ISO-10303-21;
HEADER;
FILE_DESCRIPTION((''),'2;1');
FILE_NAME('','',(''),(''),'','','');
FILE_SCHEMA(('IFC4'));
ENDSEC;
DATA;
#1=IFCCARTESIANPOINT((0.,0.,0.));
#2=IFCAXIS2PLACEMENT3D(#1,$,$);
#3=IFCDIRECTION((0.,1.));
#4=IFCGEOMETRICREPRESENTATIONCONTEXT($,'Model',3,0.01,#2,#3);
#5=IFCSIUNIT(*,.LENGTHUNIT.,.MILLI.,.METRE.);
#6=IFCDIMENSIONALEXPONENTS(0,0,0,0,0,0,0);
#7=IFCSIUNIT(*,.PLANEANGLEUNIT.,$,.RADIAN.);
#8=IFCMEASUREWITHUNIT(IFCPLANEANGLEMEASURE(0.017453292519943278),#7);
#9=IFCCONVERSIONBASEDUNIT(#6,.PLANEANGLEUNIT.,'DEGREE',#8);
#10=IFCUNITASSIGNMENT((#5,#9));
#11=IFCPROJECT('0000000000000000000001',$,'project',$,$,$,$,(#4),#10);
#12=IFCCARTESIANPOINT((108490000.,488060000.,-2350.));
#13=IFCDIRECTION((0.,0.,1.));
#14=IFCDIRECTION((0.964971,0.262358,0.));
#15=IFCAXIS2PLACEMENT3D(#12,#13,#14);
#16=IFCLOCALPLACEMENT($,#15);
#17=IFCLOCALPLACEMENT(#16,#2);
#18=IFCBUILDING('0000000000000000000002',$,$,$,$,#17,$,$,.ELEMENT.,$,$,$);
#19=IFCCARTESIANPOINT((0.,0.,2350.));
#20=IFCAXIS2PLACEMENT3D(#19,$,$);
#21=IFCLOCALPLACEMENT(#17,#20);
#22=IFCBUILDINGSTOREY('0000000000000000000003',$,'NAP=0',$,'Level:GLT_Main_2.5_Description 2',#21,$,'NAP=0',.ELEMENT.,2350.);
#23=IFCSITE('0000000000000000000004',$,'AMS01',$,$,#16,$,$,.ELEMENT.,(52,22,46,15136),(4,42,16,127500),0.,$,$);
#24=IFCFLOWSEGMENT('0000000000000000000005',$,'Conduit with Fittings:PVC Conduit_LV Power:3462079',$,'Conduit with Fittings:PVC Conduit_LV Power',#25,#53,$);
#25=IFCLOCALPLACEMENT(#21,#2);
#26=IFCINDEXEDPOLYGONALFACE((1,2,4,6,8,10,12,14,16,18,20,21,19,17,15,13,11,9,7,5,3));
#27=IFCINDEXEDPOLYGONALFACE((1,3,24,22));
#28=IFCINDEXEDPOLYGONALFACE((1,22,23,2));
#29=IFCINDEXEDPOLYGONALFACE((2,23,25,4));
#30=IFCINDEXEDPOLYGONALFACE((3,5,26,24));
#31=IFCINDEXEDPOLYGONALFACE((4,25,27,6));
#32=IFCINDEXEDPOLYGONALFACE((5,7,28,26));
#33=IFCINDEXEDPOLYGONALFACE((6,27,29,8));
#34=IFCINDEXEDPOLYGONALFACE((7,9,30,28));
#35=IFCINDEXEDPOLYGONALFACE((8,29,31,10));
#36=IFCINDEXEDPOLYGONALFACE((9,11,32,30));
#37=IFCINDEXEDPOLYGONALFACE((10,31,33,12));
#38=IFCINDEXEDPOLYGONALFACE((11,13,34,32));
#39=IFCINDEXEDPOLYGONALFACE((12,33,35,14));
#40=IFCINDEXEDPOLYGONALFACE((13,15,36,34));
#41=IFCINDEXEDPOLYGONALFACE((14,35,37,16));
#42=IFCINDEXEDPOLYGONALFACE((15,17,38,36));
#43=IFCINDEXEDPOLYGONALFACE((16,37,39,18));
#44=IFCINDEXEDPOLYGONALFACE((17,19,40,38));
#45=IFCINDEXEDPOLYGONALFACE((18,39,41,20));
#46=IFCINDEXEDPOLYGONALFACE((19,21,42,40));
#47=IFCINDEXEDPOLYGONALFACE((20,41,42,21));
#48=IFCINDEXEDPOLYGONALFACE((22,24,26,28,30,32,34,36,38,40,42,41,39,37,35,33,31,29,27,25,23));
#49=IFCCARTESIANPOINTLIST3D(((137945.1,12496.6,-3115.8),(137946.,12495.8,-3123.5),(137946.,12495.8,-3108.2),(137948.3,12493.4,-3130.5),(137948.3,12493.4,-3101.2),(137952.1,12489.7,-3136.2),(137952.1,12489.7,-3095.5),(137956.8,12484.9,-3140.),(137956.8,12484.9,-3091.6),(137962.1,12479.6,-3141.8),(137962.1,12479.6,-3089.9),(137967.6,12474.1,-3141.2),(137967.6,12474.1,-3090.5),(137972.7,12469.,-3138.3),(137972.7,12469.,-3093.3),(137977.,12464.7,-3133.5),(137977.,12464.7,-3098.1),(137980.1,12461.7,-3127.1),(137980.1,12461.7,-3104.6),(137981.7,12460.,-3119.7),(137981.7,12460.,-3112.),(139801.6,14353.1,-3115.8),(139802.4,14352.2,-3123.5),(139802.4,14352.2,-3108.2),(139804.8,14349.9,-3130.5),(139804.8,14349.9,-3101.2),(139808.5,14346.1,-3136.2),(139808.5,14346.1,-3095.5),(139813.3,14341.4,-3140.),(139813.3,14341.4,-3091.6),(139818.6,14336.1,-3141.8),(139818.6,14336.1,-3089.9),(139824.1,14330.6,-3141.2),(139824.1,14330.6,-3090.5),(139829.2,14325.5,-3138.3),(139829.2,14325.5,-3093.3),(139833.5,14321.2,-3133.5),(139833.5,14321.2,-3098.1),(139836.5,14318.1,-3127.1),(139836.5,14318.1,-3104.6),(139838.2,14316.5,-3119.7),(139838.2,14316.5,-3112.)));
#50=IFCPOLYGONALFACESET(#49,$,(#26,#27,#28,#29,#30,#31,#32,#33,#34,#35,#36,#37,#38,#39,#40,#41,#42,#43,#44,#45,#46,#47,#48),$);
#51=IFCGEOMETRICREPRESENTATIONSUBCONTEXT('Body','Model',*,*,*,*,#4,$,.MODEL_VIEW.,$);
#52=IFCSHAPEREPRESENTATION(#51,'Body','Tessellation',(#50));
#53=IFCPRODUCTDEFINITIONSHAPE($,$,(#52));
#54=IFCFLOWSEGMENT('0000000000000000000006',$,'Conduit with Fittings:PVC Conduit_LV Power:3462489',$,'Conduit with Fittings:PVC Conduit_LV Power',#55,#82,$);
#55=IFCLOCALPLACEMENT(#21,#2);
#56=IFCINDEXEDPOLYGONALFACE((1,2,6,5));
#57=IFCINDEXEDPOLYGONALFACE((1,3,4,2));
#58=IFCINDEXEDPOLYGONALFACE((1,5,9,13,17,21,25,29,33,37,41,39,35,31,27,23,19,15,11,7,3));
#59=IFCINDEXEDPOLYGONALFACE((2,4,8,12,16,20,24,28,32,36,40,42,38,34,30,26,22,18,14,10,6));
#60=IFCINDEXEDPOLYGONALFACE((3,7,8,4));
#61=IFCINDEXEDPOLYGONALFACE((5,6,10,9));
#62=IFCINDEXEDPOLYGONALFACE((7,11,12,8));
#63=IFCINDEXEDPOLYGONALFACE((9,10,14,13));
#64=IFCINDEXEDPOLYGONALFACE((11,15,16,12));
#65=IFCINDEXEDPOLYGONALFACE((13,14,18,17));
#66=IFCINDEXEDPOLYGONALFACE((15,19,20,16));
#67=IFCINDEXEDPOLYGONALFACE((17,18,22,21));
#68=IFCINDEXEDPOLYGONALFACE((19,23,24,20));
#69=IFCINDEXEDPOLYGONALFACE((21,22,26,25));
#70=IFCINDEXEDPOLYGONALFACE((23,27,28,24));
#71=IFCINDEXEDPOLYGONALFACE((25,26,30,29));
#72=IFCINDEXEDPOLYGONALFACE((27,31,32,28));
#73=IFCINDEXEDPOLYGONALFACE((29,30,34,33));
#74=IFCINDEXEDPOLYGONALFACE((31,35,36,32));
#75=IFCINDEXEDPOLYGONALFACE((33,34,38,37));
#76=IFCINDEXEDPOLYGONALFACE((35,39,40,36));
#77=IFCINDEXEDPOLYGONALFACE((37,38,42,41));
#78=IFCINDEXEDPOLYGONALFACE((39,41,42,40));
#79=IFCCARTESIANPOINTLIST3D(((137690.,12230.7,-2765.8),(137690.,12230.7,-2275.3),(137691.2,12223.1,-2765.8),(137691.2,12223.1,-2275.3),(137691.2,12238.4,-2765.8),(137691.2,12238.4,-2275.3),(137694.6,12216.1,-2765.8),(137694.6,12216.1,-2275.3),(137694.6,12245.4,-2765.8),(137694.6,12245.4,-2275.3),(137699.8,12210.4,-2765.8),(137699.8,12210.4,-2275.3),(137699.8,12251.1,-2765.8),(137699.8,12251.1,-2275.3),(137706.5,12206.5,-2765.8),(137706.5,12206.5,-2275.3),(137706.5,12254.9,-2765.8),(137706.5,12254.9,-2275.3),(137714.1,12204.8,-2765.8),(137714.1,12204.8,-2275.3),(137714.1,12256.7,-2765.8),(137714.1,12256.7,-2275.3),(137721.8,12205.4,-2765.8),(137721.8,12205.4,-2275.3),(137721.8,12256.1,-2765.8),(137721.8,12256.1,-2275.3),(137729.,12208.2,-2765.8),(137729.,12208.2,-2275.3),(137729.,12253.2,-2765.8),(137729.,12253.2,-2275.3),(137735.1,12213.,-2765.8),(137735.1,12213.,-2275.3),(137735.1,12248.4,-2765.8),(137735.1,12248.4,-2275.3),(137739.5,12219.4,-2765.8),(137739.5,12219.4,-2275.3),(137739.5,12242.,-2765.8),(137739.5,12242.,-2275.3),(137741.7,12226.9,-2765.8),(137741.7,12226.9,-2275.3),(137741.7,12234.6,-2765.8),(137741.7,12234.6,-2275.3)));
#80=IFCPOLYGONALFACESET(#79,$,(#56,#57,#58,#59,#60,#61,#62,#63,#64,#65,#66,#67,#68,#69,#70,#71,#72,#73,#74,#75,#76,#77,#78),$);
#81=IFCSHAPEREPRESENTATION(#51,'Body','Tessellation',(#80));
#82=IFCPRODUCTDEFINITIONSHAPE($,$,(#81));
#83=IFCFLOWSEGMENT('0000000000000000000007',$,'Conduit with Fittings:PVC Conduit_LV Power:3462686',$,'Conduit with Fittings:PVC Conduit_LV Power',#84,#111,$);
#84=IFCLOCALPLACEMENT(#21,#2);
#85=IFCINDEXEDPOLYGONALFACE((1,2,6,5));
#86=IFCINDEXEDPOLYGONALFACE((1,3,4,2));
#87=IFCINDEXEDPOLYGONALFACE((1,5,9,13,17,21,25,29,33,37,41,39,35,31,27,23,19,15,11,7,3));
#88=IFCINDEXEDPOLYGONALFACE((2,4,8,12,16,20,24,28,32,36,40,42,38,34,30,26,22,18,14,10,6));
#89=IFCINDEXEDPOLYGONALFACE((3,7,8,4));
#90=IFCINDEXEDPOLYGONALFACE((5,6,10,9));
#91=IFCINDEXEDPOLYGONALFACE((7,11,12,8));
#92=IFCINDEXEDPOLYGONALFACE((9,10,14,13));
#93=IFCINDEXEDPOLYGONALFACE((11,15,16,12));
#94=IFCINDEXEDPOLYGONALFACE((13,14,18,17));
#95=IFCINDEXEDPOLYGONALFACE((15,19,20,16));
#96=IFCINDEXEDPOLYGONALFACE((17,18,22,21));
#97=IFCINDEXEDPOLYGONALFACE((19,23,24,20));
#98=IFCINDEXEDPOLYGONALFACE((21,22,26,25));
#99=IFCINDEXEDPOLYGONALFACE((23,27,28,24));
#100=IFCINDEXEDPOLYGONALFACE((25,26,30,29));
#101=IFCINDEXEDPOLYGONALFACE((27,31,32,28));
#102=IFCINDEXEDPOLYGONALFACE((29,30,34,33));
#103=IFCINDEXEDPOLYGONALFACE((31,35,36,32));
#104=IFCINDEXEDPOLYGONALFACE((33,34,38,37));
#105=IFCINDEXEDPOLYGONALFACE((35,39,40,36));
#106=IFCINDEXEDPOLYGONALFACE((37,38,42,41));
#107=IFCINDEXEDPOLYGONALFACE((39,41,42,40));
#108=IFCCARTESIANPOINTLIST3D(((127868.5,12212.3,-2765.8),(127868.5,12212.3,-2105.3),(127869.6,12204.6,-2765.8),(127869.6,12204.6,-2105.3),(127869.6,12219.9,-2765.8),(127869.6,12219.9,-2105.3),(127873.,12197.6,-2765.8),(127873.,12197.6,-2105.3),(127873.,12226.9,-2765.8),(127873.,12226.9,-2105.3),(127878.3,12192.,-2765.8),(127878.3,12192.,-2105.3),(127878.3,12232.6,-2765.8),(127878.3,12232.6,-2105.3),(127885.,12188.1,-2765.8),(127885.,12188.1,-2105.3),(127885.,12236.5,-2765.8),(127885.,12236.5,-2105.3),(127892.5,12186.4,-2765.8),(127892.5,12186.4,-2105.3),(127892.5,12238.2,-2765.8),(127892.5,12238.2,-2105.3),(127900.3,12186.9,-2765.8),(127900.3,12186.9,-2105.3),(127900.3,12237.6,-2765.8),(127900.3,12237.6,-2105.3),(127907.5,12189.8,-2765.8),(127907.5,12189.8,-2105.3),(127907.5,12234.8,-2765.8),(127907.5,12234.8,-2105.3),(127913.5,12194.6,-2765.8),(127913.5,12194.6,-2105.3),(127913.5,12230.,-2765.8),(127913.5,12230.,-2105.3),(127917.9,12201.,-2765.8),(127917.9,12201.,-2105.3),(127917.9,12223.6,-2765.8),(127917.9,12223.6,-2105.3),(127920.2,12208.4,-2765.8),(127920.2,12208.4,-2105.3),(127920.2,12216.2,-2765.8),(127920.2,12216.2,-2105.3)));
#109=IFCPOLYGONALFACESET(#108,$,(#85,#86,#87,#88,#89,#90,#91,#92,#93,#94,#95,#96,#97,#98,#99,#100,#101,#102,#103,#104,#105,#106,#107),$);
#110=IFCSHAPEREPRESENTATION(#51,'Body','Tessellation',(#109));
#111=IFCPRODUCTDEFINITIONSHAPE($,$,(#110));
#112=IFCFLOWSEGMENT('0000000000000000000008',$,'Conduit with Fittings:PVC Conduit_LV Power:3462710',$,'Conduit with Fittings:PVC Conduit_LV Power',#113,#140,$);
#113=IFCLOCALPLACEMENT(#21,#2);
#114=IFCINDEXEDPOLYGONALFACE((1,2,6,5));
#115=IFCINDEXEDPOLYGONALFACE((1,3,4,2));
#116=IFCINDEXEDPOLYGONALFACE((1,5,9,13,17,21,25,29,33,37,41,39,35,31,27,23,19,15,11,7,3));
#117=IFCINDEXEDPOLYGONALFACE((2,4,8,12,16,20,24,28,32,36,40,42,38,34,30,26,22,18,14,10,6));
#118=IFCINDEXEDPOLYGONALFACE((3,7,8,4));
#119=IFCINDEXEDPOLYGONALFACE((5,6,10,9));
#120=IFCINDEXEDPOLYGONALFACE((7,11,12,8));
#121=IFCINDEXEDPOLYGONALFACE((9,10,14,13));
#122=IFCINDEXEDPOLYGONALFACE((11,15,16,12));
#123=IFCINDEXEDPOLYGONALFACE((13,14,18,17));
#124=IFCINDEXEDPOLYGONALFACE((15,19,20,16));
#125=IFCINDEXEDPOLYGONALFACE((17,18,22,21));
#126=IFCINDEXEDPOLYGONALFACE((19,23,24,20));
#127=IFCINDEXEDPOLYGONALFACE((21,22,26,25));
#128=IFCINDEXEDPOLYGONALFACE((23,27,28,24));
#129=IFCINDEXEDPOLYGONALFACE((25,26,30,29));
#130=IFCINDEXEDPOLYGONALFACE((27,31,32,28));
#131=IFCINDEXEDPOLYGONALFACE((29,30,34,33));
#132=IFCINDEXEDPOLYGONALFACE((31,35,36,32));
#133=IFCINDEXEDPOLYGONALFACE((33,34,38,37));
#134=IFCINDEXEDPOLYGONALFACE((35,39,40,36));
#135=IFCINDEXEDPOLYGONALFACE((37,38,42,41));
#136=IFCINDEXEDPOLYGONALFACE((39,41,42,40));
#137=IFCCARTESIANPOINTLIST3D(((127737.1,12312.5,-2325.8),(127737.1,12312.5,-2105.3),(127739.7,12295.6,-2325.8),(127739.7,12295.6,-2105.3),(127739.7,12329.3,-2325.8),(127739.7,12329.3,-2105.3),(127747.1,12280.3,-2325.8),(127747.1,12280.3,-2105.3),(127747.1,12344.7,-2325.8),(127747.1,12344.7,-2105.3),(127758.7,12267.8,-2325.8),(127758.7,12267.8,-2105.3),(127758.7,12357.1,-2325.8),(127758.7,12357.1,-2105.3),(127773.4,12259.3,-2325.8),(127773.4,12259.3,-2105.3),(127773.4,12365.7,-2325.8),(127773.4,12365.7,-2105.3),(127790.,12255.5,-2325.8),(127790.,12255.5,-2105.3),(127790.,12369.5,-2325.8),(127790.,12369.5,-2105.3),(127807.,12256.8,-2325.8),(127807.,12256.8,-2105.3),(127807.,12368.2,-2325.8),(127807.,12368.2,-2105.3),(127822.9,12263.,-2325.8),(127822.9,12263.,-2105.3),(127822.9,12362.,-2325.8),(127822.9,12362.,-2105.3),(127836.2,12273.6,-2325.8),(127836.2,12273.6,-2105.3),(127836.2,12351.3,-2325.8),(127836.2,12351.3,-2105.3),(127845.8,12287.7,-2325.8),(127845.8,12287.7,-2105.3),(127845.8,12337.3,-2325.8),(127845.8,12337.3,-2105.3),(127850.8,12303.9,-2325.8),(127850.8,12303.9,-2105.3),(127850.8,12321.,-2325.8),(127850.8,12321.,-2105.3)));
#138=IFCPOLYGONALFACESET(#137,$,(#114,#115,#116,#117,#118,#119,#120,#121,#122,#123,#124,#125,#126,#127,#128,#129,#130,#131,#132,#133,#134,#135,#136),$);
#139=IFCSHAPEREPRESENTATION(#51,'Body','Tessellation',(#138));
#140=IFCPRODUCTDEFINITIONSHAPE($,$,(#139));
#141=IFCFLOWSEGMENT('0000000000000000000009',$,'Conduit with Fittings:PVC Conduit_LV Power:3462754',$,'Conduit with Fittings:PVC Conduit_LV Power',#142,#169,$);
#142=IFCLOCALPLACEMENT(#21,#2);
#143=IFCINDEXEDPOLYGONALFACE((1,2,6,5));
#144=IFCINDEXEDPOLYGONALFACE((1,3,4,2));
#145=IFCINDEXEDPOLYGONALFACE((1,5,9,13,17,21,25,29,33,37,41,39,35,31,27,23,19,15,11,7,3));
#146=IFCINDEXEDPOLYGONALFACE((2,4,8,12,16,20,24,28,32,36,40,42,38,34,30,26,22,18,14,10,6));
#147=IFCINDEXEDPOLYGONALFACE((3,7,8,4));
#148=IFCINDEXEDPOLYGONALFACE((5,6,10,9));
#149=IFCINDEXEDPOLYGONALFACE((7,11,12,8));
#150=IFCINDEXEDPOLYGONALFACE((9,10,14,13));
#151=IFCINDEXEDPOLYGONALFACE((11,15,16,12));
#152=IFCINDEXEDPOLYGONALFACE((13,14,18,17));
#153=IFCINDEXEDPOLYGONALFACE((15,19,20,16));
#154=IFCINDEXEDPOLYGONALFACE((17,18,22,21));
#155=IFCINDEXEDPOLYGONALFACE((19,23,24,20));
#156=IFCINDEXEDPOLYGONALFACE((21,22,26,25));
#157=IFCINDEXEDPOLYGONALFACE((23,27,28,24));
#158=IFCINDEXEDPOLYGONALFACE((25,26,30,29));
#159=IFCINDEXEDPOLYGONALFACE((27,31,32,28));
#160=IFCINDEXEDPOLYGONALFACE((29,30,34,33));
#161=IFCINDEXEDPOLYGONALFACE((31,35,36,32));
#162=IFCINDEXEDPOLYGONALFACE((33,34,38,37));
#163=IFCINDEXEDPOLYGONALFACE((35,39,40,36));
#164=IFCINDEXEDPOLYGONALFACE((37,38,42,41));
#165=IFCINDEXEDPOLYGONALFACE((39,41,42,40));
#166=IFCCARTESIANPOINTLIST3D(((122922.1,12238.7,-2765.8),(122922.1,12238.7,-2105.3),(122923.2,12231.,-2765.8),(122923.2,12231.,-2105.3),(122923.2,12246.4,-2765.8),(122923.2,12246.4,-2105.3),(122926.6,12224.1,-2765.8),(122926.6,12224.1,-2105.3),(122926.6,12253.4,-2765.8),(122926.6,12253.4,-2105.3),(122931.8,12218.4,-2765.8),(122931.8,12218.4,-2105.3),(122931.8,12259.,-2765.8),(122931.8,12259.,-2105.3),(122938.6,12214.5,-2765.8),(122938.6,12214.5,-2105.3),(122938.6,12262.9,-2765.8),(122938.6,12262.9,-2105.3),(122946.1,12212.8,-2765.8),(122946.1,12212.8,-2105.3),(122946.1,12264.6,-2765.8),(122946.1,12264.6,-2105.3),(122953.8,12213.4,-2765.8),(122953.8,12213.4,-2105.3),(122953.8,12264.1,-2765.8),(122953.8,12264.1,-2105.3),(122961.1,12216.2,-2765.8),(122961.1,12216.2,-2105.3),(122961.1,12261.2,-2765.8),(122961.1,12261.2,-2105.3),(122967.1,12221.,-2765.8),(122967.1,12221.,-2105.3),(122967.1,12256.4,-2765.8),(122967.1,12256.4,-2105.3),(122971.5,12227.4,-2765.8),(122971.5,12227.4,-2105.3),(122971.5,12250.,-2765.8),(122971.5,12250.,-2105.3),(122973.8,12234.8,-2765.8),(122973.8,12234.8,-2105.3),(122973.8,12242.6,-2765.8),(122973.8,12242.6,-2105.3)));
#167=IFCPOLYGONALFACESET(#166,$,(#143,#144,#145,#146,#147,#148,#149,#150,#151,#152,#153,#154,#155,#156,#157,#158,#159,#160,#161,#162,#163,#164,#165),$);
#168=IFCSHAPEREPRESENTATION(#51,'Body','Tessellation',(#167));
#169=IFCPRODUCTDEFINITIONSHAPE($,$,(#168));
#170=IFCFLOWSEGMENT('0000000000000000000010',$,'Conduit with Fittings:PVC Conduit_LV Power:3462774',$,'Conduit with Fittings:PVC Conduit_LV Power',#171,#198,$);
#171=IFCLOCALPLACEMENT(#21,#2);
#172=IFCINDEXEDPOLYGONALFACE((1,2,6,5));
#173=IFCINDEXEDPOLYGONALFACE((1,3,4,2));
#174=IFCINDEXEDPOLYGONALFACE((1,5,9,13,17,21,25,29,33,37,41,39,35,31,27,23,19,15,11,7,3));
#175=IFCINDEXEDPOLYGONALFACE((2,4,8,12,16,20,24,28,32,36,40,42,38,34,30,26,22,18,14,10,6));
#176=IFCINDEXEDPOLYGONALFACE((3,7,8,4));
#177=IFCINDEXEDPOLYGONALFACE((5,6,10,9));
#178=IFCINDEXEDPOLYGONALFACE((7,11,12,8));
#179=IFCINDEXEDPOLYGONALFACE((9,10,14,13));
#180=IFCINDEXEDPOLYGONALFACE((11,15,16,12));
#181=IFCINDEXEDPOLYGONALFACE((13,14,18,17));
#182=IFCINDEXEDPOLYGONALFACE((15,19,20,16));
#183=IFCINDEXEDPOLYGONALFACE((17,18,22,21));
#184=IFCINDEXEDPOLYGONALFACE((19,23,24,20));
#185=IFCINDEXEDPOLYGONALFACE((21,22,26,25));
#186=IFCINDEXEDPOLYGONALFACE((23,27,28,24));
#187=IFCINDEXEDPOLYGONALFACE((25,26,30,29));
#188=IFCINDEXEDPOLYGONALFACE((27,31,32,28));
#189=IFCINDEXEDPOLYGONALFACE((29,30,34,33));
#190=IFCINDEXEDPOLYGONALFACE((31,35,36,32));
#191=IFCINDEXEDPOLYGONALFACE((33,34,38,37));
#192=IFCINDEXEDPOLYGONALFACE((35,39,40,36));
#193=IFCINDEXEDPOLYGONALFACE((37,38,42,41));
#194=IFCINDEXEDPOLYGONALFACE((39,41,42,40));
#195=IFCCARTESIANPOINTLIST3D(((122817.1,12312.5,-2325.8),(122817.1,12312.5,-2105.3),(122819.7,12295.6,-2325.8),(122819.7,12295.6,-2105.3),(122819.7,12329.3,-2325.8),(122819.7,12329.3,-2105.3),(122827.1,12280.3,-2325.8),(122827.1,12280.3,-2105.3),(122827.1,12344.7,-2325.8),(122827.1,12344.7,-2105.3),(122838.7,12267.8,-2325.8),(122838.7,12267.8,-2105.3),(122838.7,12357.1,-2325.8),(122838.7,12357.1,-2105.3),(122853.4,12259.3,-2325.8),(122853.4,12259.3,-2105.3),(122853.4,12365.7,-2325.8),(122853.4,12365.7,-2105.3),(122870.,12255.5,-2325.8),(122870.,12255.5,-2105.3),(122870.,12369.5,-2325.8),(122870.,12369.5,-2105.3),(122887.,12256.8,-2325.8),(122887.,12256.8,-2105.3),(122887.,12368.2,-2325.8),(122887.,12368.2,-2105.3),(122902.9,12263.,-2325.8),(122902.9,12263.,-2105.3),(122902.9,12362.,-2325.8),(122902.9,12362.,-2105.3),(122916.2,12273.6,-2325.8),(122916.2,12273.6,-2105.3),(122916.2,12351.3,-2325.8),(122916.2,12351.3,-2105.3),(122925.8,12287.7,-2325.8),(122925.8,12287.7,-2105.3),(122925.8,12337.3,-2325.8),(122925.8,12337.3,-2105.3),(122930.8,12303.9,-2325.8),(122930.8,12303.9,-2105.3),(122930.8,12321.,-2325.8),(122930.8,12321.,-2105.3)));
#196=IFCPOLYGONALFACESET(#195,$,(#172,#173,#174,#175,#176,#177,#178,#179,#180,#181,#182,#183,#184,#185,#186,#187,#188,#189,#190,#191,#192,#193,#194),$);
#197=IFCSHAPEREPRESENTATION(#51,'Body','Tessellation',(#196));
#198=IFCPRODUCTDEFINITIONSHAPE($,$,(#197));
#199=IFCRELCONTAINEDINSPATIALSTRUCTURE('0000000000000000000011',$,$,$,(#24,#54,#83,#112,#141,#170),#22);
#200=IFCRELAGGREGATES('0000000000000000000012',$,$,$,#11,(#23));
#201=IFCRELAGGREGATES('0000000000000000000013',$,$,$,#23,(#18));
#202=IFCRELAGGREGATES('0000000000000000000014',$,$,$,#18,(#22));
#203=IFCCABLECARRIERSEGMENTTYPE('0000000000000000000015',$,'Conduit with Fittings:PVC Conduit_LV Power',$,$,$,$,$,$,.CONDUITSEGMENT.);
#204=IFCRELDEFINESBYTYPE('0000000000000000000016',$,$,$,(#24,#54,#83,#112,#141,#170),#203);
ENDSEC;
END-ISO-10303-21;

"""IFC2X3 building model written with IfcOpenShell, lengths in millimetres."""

from ifc_helpers import new_model, entity, si_unit, converted_unit, direction, frame, frame_2d, origin, origin_2d_with_axis, place, context, subcontext, project, spatial, circle, extrude, type_object, element, save


model = new_model("IFC2X3")

# Units and contexts
model_context = context("Model", 3, precision=0.01, world=origin(), true_north=direction((0.0, 1.0)))
body_context = subcontext(model_context, "Body", "Model", "MODEL_VIEW")
ifc_project = project(units=[si_unit("LENGTHUNIT", "METRE", prefix="MILLI"), converted_unit("PLANEANGLEUNIT", "DEGREE", entity("IfcPlaneAngleMeasure", 0.017453292519943278), si_unit("PLANEANGLEUNIT", "RADIAN"), dimensions=[0, 0, 0, 0, 0, 0, 0])], contexts=[model_context])

# Site, building, storey
site_placement = place(None, frame((108490000.0, 488060000.0, -2350.0), z_axis=(0.0, 0.0, 1.0), x_axis=(0.964971, 0.262358, 0.0)))
site = spatial("IfcSite", under=ifc_project, at=site_placement, Name="AMS01", CompositionType="ELEMENT", RefLatitude=(52, 22, 46, 15136), RefLongitude=(4, 42, 16, 127500), RefElevation=0.0)
building_placement = place(site_placement, origin())
building = spatial("IfcBuilding", under=site, at=building_placement, CompositionType="ELEMENT")
storey_placement = place(building_placement, frame((0.0, 0.0, 2350.0)))
storey = spatial("IfcBuildingStorey", under=building, at=storey_placement, Name="NAP=0", ObjectType="Level:GLT_Main_2.5_Description 2", LongName="NAP=0", CompositionType="ELEMENT", Elevation=2350.0)

# Flow segments
cable_carrier_segment_type = type_object("IfcCableCarrierSegmentType", Name="Conduit with Fittings:PVC Conduit_LV Power", PredefinedType="CONDUITSEGMENT")
flow_segment_1_placement = place(storey_placement, origin())
element("IfcFlowSegment", 1, at=flow_segment_1_placement, inside=storey, type_object=cable_carrier_segment_type, Name="Conduit with Fittings:PVC Conduit_LV Power:3462079", ObjectType="Conduit with Fittings:PVC Conduit_LV Power", context=body_context, shape_type="SweptSolid", body=[
    extrude(circle(Radius=26.0, at=frame_2d((0.0, 0.0), x_axis=(1.0, 0.0))), frame((137963.5, 12478.2, -3115.8), z_axis=(0.707107, 0.707107, 0.0), x_axis=(-0.707107, 0.707107, 0.0)), (0.0, 0.0, 1.0), 2625.4),
])
flow_segment_2_placement = place(storey_placement, origin())
element("IfcFlowSegment", 2, at=flow_segment_2_placement, inside=storey, type_object=cable_carrier_segment_type, Name="Conduit with Fittings:PVC Conduit_LV Power:3462489", ObjectType="Conduit with Fittings:PVC Conduit_LV Power", context=body_context, shape_type="SweptSolid", body=[
    extrude(circle(Radius=26.0, at=frame_2d((0.0, 0.0), x_axis=(1.0, 0.0))), frame((137716.0, 12230.7, -2765.8), z_axis=(0.0, 0.0, 1.0), x_axis=(-1.0, 0.0, 0.0)), (0.0, 0.0, 1.0), 490.6),
])
flow_segment_3_placement = place(storey_placement, origin())
element("IfcFlowSegment", 3, at=flow_segment_3_placement, inside=storey, type_object=cable_carrier_segment_type, Name="Conduit with Fittings:PVC Conduit_LV Power:3462686", ObjectType="Conduit with Fittings:PVC Conduit_LV Power", context=body_context, shape_type="SweptSolid", body=[
    extrude(circle(Radius=26.0, at=frame_2d((0.0, 0.0), x_axis=(1.0, 0.0))), frame((127894.5, 12212.3, -2765.8), z_axis=(0.0, 0.0, 1.0), x_axis=(-1.0, 0.0, 0.0)), (0.0, 0.0, 1.0), 660.6),
])
flow_segment_4_placement = place(storey_placement, origin())
element("IfcFlowSegment", 4, at=flow_segment_4_placement, inside=storey, type_object=cable_carrier_segment_type, Name="Conduit with Fittings:PVC Conduit_LV Power:3462710", ObjectType="Conduit with Fittings:PVC Conduit_LV Power", context=body_context, shape_type="SweptSolid", body=[
    extrude(circle(Radius=57.2, at=origin_2d_with_axis()), frame((127794.3, 12312.5, -2325.8), z_axis=(0.0, 0.0, 1.0), x_axis=(-1.0, 0.0, 0.0)), (0.0, 0.0, 1.0), 220.6),
])
flow_segment_5_placement = place(storey_placement, origin())
element("IfcFlowSegment", 5, at=flow_segment_5_placement, inside=storey, type_object=cable_carrier_segment_type, Name="Conduit with Fittings:PVC Conduit_LV Power:3462754", ObjectType="Conduit with Fittings:PVC Conduit_LV Power", context=body_context, shape_type="SweptSolid", body=[
    extrude(circle(Radius=26.0, at=origin_2d_with_axis()), frame((122948.1, 12238.7, -2765.8), z_axis=(0.0, 0.0, 1.0), x_axis=(-1.0, 0.0, 0.0)), (0.0, 0.0, 1.0), 660.6),
])
flow_segment_6_placement = place(storey_placement, origin())
element("IfcFlowSegment", 6, at=flow_segment_6_placement, inside=storey, type_object=cable_carrier_segment_type, Name="Conduit with Fittings:PVC Conduit_LV Power:3462774", ObjectType="Conduit with Fittings:PVC Conduit_LV Power", context=body_context, shape_type="SweptSolid", body=[
    extrude(circle(Radius=57.2, at=origin_2d_with_axis()), frame((122874.3, 12312.5, -2325.8), z_axis=(0.0, 0.0, 1.0), x_axis=(-1.0, 0.0, 0.0)), (0.0, 0.0, 1.0), 220.6),
])

save(model, "model.ifc")
